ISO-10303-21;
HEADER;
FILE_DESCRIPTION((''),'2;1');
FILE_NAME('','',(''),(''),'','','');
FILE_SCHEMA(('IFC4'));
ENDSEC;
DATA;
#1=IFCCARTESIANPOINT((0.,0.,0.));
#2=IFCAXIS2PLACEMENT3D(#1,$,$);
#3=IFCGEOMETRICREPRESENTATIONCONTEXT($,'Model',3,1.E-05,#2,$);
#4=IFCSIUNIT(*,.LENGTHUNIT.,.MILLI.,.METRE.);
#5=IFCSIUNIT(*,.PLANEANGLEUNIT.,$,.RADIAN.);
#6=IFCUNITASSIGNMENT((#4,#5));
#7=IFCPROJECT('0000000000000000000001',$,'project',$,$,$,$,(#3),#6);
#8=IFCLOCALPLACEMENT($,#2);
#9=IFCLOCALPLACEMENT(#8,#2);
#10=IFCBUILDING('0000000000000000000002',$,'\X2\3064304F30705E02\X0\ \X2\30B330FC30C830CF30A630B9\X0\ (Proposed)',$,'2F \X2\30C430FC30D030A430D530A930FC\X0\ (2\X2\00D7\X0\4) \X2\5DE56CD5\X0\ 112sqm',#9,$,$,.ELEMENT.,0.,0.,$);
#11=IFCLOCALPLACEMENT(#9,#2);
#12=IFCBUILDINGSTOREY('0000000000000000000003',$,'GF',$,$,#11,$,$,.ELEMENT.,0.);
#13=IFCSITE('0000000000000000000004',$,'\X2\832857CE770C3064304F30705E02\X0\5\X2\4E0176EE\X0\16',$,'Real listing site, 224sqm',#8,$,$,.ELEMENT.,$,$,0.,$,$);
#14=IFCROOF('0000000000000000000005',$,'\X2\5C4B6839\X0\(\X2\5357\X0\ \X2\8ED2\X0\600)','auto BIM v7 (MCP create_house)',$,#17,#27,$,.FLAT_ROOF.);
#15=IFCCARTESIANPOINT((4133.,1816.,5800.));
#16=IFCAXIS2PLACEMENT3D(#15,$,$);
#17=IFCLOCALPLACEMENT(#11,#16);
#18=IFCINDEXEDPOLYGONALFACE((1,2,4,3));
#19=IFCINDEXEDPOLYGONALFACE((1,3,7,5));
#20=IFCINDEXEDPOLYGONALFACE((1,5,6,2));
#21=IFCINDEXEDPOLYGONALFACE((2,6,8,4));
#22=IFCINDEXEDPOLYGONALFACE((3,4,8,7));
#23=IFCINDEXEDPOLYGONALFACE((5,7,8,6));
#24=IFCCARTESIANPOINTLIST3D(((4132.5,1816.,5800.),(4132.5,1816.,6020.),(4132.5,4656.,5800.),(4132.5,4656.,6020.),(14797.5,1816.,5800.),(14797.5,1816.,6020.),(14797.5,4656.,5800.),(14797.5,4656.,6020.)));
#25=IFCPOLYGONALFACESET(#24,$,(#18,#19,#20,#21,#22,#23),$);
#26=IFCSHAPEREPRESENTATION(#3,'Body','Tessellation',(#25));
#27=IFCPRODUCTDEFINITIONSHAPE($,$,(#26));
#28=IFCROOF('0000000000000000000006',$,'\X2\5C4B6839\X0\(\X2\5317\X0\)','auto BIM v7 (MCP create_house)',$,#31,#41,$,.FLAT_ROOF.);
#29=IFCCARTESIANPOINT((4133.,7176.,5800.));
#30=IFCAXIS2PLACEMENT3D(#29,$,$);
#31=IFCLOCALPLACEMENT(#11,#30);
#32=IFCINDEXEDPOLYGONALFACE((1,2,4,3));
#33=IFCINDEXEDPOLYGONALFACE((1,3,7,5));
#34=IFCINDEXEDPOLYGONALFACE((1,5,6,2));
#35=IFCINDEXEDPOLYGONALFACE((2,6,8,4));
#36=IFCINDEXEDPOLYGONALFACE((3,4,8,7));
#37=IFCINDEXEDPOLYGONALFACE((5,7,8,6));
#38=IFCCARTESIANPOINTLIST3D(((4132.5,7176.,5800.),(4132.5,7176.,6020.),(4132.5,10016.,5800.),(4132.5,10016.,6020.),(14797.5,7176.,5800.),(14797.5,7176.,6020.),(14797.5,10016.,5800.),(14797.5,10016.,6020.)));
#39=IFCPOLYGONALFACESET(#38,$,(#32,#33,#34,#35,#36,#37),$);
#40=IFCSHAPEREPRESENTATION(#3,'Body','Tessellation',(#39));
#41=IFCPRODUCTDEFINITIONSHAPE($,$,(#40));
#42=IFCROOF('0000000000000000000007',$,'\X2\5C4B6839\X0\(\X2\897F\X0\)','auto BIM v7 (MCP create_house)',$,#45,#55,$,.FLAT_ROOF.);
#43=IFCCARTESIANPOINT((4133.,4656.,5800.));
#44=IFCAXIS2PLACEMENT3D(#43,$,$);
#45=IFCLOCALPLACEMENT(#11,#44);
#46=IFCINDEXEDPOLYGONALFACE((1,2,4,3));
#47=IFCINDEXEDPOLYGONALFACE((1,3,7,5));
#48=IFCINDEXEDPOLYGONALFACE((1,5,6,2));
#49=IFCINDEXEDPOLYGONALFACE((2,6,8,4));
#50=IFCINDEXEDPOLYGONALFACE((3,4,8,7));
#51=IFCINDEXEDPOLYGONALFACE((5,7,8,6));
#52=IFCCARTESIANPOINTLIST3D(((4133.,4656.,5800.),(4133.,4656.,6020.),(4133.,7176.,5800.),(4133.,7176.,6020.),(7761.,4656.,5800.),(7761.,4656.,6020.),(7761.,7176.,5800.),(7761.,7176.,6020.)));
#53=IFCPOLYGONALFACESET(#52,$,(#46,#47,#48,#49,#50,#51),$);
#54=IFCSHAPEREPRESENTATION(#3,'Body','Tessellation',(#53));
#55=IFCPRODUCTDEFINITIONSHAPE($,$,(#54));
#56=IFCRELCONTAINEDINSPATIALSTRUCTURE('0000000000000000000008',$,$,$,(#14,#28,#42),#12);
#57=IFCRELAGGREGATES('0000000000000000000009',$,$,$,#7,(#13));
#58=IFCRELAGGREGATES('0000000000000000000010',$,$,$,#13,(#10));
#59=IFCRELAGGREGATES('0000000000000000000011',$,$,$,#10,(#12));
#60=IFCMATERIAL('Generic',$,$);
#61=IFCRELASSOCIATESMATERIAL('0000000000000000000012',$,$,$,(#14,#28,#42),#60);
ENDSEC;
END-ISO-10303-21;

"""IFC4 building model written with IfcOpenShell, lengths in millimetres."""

from ifc_helpers import new_model, si_unit, frame, frame_2d, origin, place, context, project, spatial, rectangle, extrude, material, element, save


model = new_model("IFC4")

# Units and contexts
model_context = context("Model", 3, precision=1e-05, world=origin())
ifc_project = project(units=[si_unit("LENGTHUNIT", "METRE", prefix="MILLI"), si_unit("PLANEANGLEUNIT", "RADIAN")], contexts=[model_context])

# Site, building, storey
site_placement = place(None, origin())
site = spatial("IfcSite", under=ifc_project, at=site_placement, Name="茨城県つくば市5丁目16", ObjectType="Real listing site, 224sqm", CompositionType="ELEMENT", RefElevation=0.0)
building_placement = place(site_placement, origin())
building = spatial("IfcBuilding", under=site, at=building_placement, Name="つくば市 コートハウス (Proposed)", ObjectType="2F ツーバイフォー (2×4) 工法 112sqm", CompositionType="ELEMENT", ElevationOfRefHeight=0.0, ElevationOfTerrain=0.0)
storey_placement = place(building_placement, origin())
storey = spatial("IfcBuildingStorey", under=building, at=storey_placement, Name="GF", CompositionType="ELEMENT", Elevation=0.0)

# Shared definitions
ifc_material = material(Name="Generic")

# Roofs
roof_1_placement = place(storey_placement, frame((4133.0, 1816.0, 5800.0)))
element("IfcRoof", 1, at=roof_1_placement, inside=storey, material=ifc_material, Name="屋根(南 軒600)", Description="auto BIM v7 (MCP create_house)", PredefinedType="FLAT_ROOF", context=model_context, shape_type="SweptSolid", body=[
    extrude(rectangle(XDim=10665.0, YDim=2840.0, at=frame_2d((5332.0, 1420.0))), frame((4133.0, 1816.0, 5800.0)), (0.0, 0.0, 1.0), 220.0),
])
roof_2_placement = place(storey_placement, frame((4133.0, 7176.0, 5800.0)))
element("IfcRoof", 2, at=roof_2_placement, inside=storey, material=ifc_material, Name="屋根(北)", Description="auto BIM v7 (MCP create_house)", PredefinedType="FLAT_ROOF", context=model_context, shape_type="SweptSolid", body=[
    extrude(rectangle(XDim=10665.0, YDim=2840.0, at=frame_2d((5332.0, 1420.0))), frame((4133.0, 7176.0, 5800.0)), (0.0, 0.0, 1.0), 220.0),
])
roof_3_placement = place(storey_placement, frame((4133.0, 4656.0, 5800.0)))
element("IfcRoof", 3, at=roof_3_placement, inside=storey, material=ifc_material, Name="屋根(西)", Description="auto BIM v7 (MCP create_house)", PredefinedType="FLAT_ROOF", context=model_context, shape_type="SweptSolid", body=[
    extrude(rectangle(XDim=3628.0, YDim=2520.0, at=frame_2d((1814.0, 1260.0))), frame((4133.0, 4656.0, 5800.0)), (0.0, 0.0, 1.0), 220.0),
])

save(model, "model.ifc")
